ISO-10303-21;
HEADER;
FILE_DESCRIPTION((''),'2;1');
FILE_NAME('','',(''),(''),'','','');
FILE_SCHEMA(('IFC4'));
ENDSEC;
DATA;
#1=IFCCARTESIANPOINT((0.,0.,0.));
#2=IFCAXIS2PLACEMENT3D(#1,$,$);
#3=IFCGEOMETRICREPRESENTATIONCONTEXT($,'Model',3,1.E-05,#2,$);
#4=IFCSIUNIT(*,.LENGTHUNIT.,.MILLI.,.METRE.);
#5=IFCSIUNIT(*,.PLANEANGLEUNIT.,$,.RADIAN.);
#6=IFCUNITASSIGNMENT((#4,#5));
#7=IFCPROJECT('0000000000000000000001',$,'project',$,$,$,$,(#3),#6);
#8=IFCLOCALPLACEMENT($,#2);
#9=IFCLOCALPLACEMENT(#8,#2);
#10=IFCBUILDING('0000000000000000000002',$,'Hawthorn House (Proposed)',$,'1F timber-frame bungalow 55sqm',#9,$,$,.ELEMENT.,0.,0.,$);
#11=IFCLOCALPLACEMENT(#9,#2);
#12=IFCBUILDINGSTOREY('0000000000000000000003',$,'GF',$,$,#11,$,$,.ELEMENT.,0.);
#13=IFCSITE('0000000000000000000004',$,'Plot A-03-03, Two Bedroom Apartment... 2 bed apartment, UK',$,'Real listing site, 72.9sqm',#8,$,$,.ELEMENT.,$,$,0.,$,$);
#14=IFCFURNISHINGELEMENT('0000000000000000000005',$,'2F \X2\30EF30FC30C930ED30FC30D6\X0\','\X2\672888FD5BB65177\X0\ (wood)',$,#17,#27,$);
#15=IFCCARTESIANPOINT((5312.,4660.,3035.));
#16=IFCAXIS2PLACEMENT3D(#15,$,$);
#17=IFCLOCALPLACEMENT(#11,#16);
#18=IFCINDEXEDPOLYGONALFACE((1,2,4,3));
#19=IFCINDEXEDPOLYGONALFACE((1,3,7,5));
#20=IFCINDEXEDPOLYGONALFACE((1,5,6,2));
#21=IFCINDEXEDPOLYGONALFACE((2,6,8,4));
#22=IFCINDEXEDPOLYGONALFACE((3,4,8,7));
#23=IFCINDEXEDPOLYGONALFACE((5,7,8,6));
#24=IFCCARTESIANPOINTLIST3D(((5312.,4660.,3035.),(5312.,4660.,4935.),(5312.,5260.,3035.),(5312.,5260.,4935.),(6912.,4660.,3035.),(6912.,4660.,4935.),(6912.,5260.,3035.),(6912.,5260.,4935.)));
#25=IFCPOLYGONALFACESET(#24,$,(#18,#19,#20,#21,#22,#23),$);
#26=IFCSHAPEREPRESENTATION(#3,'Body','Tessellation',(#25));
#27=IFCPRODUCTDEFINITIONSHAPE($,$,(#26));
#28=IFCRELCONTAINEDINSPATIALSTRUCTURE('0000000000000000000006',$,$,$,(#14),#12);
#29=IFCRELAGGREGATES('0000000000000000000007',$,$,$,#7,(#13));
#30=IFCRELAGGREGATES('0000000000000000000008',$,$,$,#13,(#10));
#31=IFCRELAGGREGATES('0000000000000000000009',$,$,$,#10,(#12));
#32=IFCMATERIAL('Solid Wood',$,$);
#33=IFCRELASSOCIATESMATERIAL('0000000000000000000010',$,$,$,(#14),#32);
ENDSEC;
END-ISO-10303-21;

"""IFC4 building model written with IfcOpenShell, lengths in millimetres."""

from ifc_helpers import new_model, si_unit, frame, frame_2d, origin, place, context, project, spatial, rectangle, extrude, material, element, save


model = new_model("IFC4")

# Units and contexts
model_context = context("Model", 3, precision=1e-05, world=origin())
ifc_project = project(units=[si_unit("LENGTHUNIT", "METRE", prefix="MILLI"), si_unit("PLANEANGLEUNIT", "RADIAN")], contexts=[model_context])

# Site, building, storey
site_placement = place(None, origin())
site = spatial("IfcSite", under=ifc_project, at=site_placement, Name="Plot A-03-03, Two Bedroom Apartment... 2 bed apartment, UK", ObjectType="Real listing site, 72.9sqm", CompositionType="ELEMENT", RefElevation=0.0)
building_placement = place(site_placement, origin())
building = spatial("IfcBuilding", under=site, at=building_placement, Name="Hawthorn House (Proposed)", ObjectType="1F timber-frame bungalow 55sqm", CompositionType="ELEMENT", ElevationOfRefHeight=0.0, ElevationOfTerrain=0.0)
storey_placement = place(building_placement, origin())
storey = spatial("IfcBuildingStorey", under=building, at=storey_placement, Name="GF", CompositionType="ELEMENT", Elevation=0.0)

# Shared definitions
ifc_material_1 = material(Name="Solid Wood")

# Furnishing element
furnishing_1_placement = place(storey_placement, frame((5312.0, 4660.0, 3035.0)))
element("IfcFurnishingElement", 1, at=furnishing_1_placement, inside=storey, material=ifc_material_1, Name="2F ワードローブ", Description="木製家具 (wood)", context=model_context, shape_type="SweptSolid", body=[
    extrude(rectangle(XDim=1600.0, YDim=600.0, at=frame_2d((800.0, 300.0))), frame((5312.0, 4660.0, 3035.0)), (0.0, 0.0, 1.0), 1900.0),
])

save(model, "model.ifc")
